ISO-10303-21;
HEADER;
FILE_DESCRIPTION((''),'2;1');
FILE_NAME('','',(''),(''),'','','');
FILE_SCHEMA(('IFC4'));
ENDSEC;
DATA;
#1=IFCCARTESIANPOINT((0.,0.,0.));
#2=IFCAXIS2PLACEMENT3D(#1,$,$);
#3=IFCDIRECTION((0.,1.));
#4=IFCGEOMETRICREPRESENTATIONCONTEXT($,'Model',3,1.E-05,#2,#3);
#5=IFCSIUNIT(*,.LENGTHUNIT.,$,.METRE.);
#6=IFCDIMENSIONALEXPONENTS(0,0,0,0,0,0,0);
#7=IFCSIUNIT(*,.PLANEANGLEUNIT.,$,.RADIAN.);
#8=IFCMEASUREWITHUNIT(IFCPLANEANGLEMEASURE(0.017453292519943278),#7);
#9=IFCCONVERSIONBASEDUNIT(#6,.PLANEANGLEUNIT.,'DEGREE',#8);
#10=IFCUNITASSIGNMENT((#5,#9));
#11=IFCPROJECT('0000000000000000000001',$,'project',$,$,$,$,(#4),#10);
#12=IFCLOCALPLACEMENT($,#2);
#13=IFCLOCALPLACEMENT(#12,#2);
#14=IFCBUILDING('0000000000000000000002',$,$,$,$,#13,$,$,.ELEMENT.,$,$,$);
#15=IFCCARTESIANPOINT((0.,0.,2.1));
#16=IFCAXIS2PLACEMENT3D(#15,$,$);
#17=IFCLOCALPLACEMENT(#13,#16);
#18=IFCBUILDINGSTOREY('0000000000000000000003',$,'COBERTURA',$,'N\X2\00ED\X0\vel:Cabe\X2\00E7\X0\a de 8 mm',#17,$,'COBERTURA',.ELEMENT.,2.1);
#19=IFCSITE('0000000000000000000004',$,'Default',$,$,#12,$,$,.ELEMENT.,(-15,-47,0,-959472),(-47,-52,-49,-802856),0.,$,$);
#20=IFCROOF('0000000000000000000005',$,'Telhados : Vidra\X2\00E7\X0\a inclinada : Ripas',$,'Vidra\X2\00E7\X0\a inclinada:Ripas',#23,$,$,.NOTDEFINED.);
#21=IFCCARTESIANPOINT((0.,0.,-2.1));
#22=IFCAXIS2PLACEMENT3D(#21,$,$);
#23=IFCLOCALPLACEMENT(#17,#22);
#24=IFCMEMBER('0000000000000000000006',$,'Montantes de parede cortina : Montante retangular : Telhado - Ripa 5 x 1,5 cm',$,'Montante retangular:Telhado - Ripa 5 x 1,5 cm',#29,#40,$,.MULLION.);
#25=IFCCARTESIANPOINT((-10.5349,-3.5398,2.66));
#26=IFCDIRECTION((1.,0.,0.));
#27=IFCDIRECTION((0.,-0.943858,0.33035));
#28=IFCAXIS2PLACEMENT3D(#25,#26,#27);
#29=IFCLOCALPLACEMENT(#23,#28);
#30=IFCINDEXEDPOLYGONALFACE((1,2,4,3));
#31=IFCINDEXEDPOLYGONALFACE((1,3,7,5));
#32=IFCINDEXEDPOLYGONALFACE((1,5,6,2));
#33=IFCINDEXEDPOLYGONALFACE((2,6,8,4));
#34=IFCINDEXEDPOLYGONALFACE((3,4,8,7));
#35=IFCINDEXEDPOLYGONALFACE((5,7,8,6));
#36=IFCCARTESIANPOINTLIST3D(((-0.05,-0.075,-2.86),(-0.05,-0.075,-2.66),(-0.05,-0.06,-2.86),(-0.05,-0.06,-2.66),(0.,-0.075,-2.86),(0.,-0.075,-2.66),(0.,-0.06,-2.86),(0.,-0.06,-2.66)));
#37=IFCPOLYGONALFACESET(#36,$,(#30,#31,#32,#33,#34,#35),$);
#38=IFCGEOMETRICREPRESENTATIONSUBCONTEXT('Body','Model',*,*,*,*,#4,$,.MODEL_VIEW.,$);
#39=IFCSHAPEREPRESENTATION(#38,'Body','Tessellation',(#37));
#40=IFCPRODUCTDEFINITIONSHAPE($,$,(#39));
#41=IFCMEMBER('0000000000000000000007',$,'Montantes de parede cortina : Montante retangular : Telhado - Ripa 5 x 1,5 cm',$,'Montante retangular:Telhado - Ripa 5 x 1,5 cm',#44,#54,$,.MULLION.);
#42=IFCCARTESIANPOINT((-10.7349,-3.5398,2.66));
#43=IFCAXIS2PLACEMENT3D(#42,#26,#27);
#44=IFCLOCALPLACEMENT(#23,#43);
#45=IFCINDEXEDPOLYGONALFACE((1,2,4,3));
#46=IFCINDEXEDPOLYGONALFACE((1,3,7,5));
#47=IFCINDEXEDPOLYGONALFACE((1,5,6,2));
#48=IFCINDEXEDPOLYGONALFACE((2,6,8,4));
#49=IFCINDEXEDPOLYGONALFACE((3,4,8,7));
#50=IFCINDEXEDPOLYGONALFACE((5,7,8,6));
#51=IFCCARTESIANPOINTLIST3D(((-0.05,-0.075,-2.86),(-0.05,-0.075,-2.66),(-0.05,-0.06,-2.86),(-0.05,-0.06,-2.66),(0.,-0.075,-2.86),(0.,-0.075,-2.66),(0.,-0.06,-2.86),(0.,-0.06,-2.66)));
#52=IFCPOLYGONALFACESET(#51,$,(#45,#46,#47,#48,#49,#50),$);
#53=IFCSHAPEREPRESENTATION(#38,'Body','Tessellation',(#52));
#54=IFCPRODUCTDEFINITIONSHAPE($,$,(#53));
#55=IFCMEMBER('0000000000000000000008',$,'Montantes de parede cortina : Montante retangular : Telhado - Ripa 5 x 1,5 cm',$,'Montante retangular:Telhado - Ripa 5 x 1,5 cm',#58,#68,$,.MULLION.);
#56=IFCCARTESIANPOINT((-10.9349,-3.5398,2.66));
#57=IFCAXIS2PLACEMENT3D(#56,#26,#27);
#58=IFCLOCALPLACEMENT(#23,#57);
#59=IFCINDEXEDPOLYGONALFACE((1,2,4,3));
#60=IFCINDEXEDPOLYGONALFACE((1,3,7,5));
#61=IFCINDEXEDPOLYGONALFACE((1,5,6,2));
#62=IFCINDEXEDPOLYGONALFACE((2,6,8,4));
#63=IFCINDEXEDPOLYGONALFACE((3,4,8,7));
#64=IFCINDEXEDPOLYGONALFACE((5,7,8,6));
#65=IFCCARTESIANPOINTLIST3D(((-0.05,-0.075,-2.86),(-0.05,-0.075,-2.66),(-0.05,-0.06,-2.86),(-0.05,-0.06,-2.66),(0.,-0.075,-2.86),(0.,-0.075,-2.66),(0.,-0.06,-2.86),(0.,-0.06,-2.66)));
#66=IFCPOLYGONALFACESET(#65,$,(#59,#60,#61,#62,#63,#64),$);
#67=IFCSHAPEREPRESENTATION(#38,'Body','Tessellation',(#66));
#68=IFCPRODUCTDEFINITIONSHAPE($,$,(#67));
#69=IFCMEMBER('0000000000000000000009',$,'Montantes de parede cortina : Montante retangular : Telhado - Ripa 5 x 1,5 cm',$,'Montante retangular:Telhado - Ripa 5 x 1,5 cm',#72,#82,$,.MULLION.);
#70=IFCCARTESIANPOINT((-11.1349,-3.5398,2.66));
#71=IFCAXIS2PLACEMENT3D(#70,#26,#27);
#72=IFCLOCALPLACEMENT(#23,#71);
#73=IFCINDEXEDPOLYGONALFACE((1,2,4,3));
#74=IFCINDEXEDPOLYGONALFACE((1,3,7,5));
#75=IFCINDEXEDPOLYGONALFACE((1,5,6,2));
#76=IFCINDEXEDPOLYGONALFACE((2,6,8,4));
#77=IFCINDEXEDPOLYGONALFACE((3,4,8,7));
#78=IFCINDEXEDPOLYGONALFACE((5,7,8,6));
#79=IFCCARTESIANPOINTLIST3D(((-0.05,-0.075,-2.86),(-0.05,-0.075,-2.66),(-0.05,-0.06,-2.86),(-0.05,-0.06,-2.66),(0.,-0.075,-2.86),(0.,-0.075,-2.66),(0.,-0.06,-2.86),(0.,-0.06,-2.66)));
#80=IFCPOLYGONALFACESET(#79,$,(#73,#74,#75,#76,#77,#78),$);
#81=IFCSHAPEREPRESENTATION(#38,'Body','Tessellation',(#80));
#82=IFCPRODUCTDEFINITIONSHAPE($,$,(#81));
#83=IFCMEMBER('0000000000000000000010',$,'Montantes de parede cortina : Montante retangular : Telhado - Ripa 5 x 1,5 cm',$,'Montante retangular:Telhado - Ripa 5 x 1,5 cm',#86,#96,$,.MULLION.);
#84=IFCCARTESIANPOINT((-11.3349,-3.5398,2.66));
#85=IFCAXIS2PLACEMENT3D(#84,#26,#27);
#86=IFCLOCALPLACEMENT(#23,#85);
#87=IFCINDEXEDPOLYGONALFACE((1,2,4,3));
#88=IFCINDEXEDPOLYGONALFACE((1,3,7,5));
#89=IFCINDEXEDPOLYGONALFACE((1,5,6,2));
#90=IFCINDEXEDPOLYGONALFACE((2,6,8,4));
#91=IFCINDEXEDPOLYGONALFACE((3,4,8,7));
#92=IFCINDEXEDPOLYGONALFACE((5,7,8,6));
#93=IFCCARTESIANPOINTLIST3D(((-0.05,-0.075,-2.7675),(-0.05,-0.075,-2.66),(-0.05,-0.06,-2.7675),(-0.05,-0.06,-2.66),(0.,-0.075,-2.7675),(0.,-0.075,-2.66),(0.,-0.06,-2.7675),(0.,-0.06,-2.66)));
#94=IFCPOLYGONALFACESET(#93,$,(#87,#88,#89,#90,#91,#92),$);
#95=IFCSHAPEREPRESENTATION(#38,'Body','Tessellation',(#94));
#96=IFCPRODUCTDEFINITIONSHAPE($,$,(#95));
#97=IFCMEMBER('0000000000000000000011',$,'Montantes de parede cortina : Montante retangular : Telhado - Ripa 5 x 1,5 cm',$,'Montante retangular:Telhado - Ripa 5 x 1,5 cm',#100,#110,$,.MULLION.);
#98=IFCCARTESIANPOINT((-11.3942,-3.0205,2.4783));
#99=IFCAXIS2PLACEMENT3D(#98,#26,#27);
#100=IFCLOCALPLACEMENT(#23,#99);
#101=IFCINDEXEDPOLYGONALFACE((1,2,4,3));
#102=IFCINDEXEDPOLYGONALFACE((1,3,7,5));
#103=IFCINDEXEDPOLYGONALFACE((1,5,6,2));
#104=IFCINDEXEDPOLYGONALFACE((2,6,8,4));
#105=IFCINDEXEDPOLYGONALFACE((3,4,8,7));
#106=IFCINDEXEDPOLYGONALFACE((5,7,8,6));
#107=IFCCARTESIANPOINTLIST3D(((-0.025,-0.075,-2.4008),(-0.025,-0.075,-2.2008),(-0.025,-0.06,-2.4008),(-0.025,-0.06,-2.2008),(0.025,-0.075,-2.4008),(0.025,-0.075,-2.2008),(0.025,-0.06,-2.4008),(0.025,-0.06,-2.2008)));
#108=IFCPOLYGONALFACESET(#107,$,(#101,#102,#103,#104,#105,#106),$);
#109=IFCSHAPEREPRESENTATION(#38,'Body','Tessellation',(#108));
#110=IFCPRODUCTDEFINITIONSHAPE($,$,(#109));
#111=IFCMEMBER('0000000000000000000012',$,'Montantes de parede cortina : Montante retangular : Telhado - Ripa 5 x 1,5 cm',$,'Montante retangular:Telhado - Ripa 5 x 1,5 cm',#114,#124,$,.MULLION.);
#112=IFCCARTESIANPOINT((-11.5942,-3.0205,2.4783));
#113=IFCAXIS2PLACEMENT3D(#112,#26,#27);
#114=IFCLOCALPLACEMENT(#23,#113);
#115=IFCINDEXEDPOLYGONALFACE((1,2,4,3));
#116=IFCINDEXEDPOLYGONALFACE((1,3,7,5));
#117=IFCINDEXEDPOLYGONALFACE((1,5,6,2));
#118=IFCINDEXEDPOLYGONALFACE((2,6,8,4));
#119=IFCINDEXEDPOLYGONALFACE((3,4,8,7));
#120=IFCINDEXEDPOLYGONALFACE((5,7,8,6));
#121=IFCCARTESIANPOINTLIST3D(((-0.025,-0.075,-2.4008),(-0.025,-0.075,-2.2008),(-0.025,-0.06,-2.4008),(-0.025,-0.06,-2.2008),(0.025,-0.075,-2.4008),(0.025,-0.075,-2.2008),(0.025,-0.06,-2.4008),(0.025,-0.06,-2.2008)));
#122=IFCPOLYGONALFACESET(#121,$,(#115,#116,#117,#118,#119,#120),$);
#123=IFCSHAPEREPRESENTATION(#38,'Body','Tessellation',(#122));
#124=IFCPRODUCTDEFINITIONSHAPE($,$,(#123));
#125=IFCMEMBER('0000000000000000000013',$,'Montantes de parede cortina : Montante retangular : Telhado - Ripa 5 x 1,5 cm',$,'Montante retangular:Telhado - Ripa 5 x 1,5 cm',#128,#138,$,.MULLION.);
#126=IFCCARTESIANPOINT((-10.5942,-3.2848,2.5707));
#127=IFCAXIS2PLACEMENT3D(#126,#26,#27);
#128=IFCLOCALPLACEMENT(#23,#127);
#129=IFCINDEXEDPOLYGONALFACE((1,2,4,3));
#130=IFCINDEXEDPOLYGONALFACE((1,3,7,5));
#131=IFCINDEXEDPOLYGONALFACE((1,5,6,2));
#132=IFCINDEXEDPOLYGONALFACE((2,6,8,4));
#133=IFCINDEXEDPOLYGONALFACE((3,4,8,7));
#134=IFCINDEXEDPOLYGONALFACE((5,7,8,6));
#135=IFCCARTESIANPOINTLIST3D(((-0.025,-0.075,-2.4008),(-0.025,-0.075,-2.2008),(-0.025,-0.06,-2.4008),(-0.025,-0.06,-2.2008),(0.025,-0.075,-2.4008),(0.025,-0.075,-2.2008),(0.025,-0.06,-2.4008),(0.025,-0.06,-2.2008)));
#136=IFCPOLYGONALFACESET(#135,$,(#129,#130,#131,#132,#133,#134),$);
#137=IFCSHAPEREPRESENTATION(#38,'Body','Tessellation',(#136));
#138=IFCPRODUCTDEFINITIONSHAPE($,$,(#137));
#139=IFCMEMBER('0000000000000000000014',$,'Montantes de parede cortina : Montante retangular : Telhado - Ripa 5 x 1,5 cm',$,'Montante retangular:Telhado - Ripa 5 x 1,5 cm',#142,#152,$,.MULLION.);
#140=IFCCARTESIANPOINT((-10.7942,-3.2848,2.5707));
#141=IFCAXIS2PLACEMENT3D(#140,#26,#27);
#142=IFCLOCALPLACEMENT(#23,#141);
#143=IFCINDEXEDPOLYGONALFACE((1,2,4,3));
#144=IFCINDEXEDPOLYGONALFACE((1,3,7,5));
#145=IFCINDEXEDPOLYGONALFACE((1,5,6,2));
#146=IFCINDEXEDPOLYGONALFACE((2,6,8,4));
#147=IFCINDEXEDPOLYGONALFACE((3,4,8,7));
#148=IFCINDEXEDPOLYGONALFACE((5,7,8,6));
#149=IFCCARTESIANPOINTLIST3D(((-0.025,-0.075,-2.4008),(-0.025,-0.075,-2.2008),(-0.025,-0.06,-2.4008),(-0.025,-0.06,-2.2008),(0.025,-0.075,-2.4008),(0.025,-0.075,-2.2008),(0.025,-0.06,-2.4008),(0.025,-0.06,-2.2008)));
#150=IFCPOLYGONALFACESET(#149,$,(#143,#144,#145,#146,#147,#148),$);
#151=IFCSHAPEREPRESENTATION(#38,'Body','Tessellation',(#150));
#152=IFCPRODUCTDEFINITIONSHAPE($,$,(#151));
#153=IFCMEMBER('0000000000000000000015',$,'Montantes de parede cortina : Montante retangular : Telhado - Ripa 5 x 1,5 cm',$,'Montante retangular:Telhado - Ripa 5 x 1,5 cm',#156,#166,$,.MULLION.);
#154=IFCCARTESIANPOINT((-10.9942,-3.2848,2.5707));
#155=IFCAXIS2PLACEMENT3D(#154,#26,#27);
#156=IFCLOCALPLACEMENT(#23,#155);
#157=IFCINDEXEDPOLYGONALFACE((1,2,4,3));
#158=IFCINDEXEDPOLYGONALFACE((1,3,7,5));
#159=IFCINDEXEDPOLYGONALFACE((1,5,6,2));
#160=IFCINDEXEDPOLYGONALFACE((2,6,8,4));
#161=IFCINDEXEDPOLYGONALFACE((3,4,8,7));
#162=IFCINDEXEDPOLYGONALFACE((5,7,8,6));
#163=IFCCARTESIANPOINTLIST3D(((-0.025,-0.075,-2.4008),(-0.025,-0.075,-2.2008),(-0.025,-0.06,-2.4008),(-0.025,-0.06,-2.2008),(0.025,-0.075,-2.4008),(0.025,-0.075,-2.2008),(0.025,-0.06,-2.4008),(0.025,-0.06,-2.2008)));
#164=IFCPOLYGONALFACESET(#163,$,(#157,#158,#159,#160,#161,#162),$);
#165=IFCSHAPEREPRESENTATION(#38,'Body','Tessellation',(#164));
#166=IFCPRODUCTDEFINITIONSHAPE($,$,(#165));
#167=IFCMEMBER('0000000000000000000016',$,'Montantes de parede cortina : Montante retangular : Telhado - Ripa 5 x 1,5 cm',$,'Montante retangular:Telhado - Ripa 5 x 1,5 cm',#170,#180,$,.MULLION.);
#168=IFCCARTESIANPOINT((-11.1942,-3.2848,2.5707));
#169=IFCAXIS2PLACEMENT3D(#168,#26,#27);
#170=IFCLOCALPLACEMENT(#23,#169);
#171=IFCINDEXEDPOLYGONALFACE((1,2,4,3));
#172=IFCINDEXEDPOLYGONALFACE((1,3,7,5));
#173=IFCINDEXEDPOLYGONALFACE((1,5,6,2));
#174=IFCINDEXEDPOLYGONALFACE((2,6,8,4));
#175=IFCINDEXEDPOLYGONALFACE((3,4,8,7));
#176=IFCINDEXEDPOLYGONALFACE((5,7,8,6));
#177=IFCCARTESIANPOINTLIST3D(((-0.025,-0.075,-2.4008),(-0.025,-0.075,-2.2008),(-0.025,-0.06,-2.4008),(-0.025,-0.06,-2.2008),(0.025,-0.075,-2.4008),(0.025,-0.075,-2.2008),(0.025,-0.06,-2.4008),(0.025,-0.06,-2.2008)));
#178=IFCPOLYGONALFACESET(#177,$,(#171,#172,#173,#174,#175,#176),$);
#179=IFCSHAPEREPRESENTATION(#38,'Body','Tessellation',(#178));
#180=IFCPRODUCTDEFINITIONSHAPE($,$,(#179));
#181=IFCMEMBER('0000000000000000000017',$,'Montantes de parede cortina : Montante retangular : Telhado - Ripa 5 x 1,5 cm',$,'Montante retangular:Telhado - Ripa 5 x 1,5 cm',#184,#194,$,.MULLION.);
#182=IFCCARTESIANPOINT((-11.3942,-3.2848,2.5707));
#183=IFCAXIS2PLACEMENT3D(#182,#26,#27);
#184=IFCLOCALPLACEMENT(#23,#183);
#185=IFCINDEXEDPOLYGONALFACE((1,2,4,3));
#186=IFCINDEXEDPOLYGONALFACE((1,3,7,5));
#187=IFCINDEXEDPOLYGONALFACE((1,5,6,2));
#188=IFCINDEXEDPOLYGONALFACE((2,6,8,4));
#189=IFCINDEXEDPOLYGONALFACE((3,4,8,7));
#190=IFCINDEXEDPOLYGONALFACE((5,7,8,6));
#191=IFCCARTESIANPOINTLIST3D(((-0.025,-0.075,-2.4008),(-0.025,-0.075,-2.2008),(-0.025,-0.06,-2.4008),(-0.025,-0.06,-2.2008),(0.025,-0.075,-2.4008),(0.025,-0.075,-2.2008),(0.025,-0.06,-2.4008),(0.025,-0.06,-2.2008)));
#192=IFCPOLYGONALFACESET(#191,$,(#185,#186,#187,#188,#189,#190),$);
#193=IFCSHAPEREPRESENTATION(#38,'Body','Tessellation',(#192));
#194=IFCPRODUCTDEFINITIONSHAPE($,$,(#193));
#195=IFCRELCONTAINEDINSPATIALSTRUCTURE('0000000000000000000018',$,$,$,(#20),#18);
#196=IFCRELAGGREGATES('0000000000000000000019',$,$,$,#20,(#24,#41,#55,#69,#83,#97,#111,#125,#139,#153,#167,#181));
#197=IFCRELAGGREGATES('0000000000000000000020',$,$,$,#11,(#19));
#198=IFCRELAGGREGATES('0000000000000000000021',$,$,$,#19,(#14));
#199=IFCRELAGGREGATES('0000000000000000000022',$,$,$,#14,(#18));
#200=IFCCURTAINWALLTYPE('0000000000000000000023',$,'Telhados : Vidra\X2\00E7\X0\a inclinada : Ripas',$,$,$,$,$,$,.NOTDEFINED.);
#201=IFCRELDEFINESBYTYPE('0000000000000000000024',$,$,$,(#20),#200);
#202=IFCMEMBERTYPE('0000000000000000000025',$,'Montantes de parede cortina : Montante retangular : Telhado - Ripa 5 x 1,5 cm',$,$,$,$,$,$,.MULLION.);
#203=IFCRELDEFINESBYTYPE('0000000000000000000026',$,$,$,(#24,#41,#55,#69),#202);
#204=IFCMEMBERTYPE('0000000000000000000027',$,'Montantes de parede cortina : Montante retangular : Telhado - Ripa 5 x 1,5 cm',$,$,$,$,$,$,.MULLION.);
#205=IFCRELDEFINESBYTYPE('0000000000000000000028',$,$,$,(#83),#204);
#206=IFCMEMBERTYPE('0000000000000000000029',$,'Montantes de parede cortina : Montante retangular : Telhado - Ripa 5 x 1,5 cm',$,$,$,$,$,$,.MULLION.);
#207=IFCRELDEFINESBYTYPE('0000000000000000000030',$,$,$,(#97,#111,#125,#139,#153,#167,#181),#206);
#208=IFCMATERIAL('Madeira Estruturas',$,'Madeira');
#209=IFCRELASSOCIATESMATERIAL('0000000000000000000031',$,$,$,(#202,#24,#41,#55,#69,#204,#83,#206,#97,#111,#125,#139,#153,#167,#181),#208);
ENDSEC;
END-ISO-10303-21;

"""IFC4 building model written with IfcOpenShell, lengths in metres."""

from ifc_helpers import new_model, entity, si_unit, converted_unit, direction, frame, origin, place, context, subcontext, project, spatial, indexed_curve, outline, extrude, source, transform, mapped, material, type_object, type_shapes, element, aggregate, save


model = new_model("IFC4")

# Units and contexts
model_context = context("Model", 3, precision=1e-05, world=origin(), true_north=direction((0.0, 1.0)))
body_context = subcontext(model_context, "Body", "Model", "MODEL_VIEW")
ifc_project = project(units=[si_unit("LENGTHUNIT", "METRE"), converted_unit("PLANEANGLEUNIT", "DEGREE", entity("IfcPlaneAngleMeasure", 0.017453292519943278), si_unit("PLANEANGLEUNIT", "RADIAN"), dimensions=[0, 0, 0, 0, 0, 0, 0])], contexts=[model_context])

# Site, building, storey
site_placement = place(None, origin())
site = spatial("IfcSite", under=ifc_project, at=site_placement, Name="Default", CompositionType="ELEMENT", RefLatitude=(-15, -47, 0, -959472), RefLongitude=(-47, -52, -49, -802856), RefElevation=0.0)
building_placement = place(site_placement, origin())
building = spatial("IfcBuilding", under=site, at=building_placement, CompositionType="ELEMENT")
storey_placement = place(building_placement, frame((0.0, 0.0, 2.1)))
storey = spatial("IfcBuildingStorey", under=building, at=storey_placement, Name="COBERTURA", ObjectType="Nível:Cabeça de 8 mm", LongName="COBERTURA", CompositionType="ELEMENT", Elevation=2.1)

# Roof, members
curtain_wall_type_1 = type_object("IfcCurtainWallType", Name="Telhados : Vidraça inclinada : Ripas", PredefinedType="NOTDEFINED")
roof_1_placement = place(storey_placement, frame((0.0, 0.0, -2.1)))
roof_1 = element("IfcRoof", 1, at=roof_1_placement, inside=storey, type_object=curtain_wall_type_1, Name="Telhados : Vidraça inclinada : Ripas", ObjectType="Vidraça inclinada:Ripas", PredefinedType="NOTDEFINED")
ifc_material_1 = material(Name="Madeira Estruturas", Category="Madeira")
member_type_1 = type_object("IfcMemberType", Name="Montantes de parede cortina : Montante retangular : Telhado - Ripa 5 x 1,5 cm", PredefinedType="MULLION", material=ifc_material_1)
shared_shape_1 = source(origin(), body_context, "Body", "SweptSolid", [
    extrude(outline(indexed_curve([(-0.025, -0.0075), (0.025, -0.0075), (0.025, 0.0075), (-0.025, 0.0075), (-0.025, -0.0075)], self_intersect=False)), frame((-0.025, -0.0675, -2.86), z_axis=(0.0, 0.0, 1.0), x_axis=(-1.0, 0.0, 0.0)), (0.0, 0.0, 1.0), 0.2),
])
type_shapes(member_type_1, [shared_shape_1])
member_1_placement = place(roof_1_placement, frame((-10.5349, -3.5398, 2.66), z_axis=(1.0, 0.0, 0.0), x_axis=(0.0, -0.943858, 0.33035)))
member_1 = element("IfcMember", 2, at=member_1_placement, type_object=member_type_1, material=ifc_material_1, Name="Montantes de parede cortina : Montante retangular : Telhado - Ripa 5 x 1,5 cm", ObjectType="Montante retangular:Telhado - Ripa 5 x 1,5 cm", PredefinedType="MULLION", context=body_context, shape_type="MappedRepresentation", body=[
    mapped(shared_shape_1, transform((0.0, 0.0, 0.0), scale=1.0)),
])
member_2_placement = place(roof_1_placement, frame((-10.7349, -3.5398, 2.66), z_axis=(1.0, 0.0, 0.0), x_axis=(0.0, -0.943858, 0.33035)))
member_2 = element("IfcMember", 3, at=member_2_placement, type_object=member_type_1, material=ifc_material_1, Name="Montantes de parede cortina : Montante retangular : Telhado - Ripa 5 x 1,5 cm", ObjectType="Montante retangular:Telhado - Ripa 5 x 1,5 cm", PredefinedType="MULLION", context=body_context, shape_type="MappedRepresentation", body=[
    mapped(shared_shape_1, transform((0.0, 0.0, 0.0), scale=1.0)),
])
member_3_placement = place(roof_1_placement, frame((-10.9349, -3.5398, 2.66), z_axis=(1.0, 0.0, 0.0), x_axis=(0.0, -0.943858, 0.33035)))
member_3 = element("IfcMember", 4, at=member_3_placement, type_object=member_type_1, material=ifc_material_1, Name="Montantes de parede cortina : Montante retangular : Telhado - Ripa 5 x 1,5 cm", ObjectType="Montante retangular:Telhado - Ripa 5 x 1,5 cm", PredefinedType="MULLION", context=body_context, shape_type="MappedRepresentation", body=[
    mapped(shared_shape_1, transform((0.0, 0.0, 0.0), scale=1.0)),
])
member_4_placement = place(roof_1_placement, frame((-11.1349, -3.5398, 2.66), z_axis=(1.0, 0.0, 0.0), x_axis=(0.0, -0.943858, 0.33035)))
member_4 = element("IfcMember", 5, at=member_4_placement, type_object=member_type_1, material=ifc_material_1, Name="Montantes de parede cortina : Montante retangular : Telhado - Ripa 5 x 1,5 cm", ObjectType="Montante retangular:Telhado - Ripa 5 x 1,5 cm", PredefinedType="MULLION", context=body_context, shape_type="MappedRepresentation", body=[
    mapped(shared_shape_1, transform((0.0, 0.0, 0.0), scale=1.0)),
])
member_type_2 = type_object("IfcMemberType", Name="Montantes de parede cortina : Montante retangular : Telhado - Ripa 5 x 1,5 cm", PredefinedType="MULLION", material=ifc_material_1)
shared_shape_2 = source(origin(), body_context, "Body", "SweptSolid", [
    extrude(outline(indexed_curve([(-0.025, -0.0075), (0.025, -0.0075), (0.025, 0.0075), (-0.025, 0.0075), (-0.025, -0.0075)], self_intersect=False)), frame((-0.025, -0.0675, -2.7675), z_axis=(0.0, 0.0, 1.0), x_axis=(-1.0, 0.0, 0.0)), (0.0, 0.0, 1.0), 0.1075),
])
type_shapes(member_type_2, [shared_shape_2])
member_5_placement = place(roof_1_placement, frame((-11.3349, -3.5398, 2.66), z_axis=(1.0, 0.0, 0.0), x_axis=(0.0, -0.943858, 0.33035)))
member_5 = element("IfcMember", 6, at=member_5_placement, type_object=member_type_2, material=ifc_material_1, Name="Montantes de parede cortina : Montante retangular : Telhado - Ripa 5 x 1,5 cm", ObjectType="Montante retangular:Telhado - Ripa 5 x 1,5 cm", PredefinedType="MULLION", context=body_context, shape_type="MappedRepresentation", body=[
    mapped(shared_shape_2, transform((0.0, 0.0, 0.0), scale=1.0)),
])
member_type_3 = type_object("IfcMemberType", Name="Montantes de parede cortina : Montante retangular : Telhado - Ripa 5 x 1,5 cm", PredefinedType="MULLION", material=ifc_material_1)
shared_shape_3 = source(origin(), body_context, "Body", "SweptSolid", [
    extrude(outline(indexed_curve([(-0.025, -0.0075), (0.025, -0.0075), (0.025, 0.0075), (-0.025, 0.0075), (-0.025, -0.0075)], self_intersect=False)), frame((0.0, -0.0675, -2.4008), z_axis=(0.0, 0.0, 1.0), x_axis=(-1.0, 0.0, 0.0)), (0.0, 0.0, 1.0), 0.2),
])
type_shapes(member_type_3, [shared_shape_3])
member_6_placement = place(roof_1_placement, frame((-11.3942, -3.0205, 2.4783), z_axis=(1.0, 0.0, 0.0), x_axis=(0.0, -0.943858, 0.33035)))
member_6 = element("IfcMember", 7, at=member_6_placement, type_object=member_type_3, material=ifc_material_1, Name="Montantes de parede cortina : Montante retangular : Telhado - Ripa 5 x 1,5 cm", ObjectType="Montante retangular:Telhado - Ripa 5 x 1,5 cm", PredefinedType="MULLION", context=body_context, shape_type="MappedRepresentation", body=[
    mapped(shared_shape_3, transform((0.0, 0.0, 0.0), scale=1.0)),
])
member_7_placement = place(roof_1_placement, frame((-11.5942, -3.0205, 2.4783), z_axis=(1.0, 0.0, 0.0), x_axis=(0.0, -0.943858, 0.33035)))
member_7 = element("IfcMember", 8, at=member_7_placement, type_object=member_type_3, material=ifc_material_1, Name="Montantes de parede cortina : Montante retangular : Telhado - Ripa 5 x 1,5 cm", ObjectType="Montante retangular:Telhado - Ripa 5 x 1,5 cm", PredefinedType="MULLION", context=body_context, shape_type="MappedRepresentation", body=[
    mapped(shared_shape_3, transform((0.0, 0.0, 0.0), scale=1.0)),
])
member_8_placement = place(roof_1_placement, frame((-10.5942, -3.2848, 2.5707), z_axis=(1.0, 0.0, 0.0), x_axis=(0.0, -0.943858, 0.33035)))
member_8 = element("IfcMember", 9, at=member_8_placement, type_object=member_type_3, material=ifc_material_1, Name="Montantes de parede cortina : Montante retangular : Telhado - Ripa 5 x 1,5 cm", ObjectType="Montante retangular:Telhado - Ripa 5 x 1,5 cm", PredefinedType="MULLION", context=body_context, shape_type="MappedRepresentation", body=[
    mapped(shared_shape_3, transform((0.0, 0.0, 0.0), scale=1.0)),
])
member_9_placement = place(roof_1_placement, frame((-10.7942, -3.2848, 2.5707), z_axis=(1.0, 0.0, 0.0), x_axis=(0.0, -0.943858, 0.33035)))
member_9 = element("IfcMember", 10, at=member_9_placement, type_object=member_type_3, material=ifc_material_1, Name="Montantes de parede cortina : Montante retangular : Telhado - Ripa 5 x 1,5 cm", ObjectType="Montante retangular:Telhado - Ripa 5 x 1,5 cm", PredefinedType="MULLION", context=body_context, shape_type="MappedRepresentation", body=[
    mapped(shared_shape_3, transform((0.0, 0.0, 0.0), scale=1.0)),
])
member_10_placement = place(roof_1_placement, frame((-10.9942, -3.2848, 2.5707), z_axis=(1.0, 0.0, 0.0), x_axis=(0.0, -0.943858, 0.33035)))
member_10 = element("IfcMember", 11, at=member_10_placement, type_object=member_type_3, material=ifc_material_1, Name="Montantes de parede cortina : Montante retangular : Telhado - Ripa 5 x 1,5 cm", ObjectType="Montante retangular:Telhado - Ripa 5 x 1,5 cm", PredefinedType="MULLION", context=body_context, shape_type="MappedRepresentation", body=[
    mapped(shared_shape_3, transform((0.0, 0.0, 0.0), scale=1.0)),
])
member_11_placement = place(roof_1_placement, frame((-11.1942, -3.2848, 2.5707), z_axis=(1.0, 0.0, 0.0), x_axis=(0.0, -0.943858, 0.33035)))
member_11 = element("IfcMember", 12, at=member_11_placement, type_object=member_type_3, material=ifc_material_1, Name="Montantes de parede cortina : Montante retangular : Telhado - Ripa 5 x 1,5 cm", ObjectType="Montante retangular:Telhado - Ripa 5 x 1,5 cm", PredefinedType="MULLION", context=body_context, shape_type="MappedRepresentation", body=[
    mapped(shared_shape_3, transform((0.0, 0.0, 0.0), scale=1.0)),
])
member_12_placement = place(roof_1_placement, frame((-11.3942, -3.2848, 2.5707), z_axis=(1.0, 0.0, 0.0), x_axis=(0.0, -0.943858, 0.33035)))
member_12 = element("IfcMember", 13, at=member_12_placement, type_object=member_type_3, material=ifc_material_1, Name="Montantes de parede cortina : Montante retangular : Telhado - Ripa 5 x 1,5 cm", ObjectType="Montante retangular:Telhado - Ripa 5 x 1,5 cm", PredefinedType="MULLION", context=body_context, shape_type="MappedRepresentation", body=[
    mapped(shared_shape_3, transform((0.0, 0.0, 0.0), scale=1.0)),
])
aggregate(roof_1, [member_1, member_2, member_3, member_4, member_5, member_6, member_7, member_8, member_9, member_10, member_11, member_12])

save(model, "model.ifc")
